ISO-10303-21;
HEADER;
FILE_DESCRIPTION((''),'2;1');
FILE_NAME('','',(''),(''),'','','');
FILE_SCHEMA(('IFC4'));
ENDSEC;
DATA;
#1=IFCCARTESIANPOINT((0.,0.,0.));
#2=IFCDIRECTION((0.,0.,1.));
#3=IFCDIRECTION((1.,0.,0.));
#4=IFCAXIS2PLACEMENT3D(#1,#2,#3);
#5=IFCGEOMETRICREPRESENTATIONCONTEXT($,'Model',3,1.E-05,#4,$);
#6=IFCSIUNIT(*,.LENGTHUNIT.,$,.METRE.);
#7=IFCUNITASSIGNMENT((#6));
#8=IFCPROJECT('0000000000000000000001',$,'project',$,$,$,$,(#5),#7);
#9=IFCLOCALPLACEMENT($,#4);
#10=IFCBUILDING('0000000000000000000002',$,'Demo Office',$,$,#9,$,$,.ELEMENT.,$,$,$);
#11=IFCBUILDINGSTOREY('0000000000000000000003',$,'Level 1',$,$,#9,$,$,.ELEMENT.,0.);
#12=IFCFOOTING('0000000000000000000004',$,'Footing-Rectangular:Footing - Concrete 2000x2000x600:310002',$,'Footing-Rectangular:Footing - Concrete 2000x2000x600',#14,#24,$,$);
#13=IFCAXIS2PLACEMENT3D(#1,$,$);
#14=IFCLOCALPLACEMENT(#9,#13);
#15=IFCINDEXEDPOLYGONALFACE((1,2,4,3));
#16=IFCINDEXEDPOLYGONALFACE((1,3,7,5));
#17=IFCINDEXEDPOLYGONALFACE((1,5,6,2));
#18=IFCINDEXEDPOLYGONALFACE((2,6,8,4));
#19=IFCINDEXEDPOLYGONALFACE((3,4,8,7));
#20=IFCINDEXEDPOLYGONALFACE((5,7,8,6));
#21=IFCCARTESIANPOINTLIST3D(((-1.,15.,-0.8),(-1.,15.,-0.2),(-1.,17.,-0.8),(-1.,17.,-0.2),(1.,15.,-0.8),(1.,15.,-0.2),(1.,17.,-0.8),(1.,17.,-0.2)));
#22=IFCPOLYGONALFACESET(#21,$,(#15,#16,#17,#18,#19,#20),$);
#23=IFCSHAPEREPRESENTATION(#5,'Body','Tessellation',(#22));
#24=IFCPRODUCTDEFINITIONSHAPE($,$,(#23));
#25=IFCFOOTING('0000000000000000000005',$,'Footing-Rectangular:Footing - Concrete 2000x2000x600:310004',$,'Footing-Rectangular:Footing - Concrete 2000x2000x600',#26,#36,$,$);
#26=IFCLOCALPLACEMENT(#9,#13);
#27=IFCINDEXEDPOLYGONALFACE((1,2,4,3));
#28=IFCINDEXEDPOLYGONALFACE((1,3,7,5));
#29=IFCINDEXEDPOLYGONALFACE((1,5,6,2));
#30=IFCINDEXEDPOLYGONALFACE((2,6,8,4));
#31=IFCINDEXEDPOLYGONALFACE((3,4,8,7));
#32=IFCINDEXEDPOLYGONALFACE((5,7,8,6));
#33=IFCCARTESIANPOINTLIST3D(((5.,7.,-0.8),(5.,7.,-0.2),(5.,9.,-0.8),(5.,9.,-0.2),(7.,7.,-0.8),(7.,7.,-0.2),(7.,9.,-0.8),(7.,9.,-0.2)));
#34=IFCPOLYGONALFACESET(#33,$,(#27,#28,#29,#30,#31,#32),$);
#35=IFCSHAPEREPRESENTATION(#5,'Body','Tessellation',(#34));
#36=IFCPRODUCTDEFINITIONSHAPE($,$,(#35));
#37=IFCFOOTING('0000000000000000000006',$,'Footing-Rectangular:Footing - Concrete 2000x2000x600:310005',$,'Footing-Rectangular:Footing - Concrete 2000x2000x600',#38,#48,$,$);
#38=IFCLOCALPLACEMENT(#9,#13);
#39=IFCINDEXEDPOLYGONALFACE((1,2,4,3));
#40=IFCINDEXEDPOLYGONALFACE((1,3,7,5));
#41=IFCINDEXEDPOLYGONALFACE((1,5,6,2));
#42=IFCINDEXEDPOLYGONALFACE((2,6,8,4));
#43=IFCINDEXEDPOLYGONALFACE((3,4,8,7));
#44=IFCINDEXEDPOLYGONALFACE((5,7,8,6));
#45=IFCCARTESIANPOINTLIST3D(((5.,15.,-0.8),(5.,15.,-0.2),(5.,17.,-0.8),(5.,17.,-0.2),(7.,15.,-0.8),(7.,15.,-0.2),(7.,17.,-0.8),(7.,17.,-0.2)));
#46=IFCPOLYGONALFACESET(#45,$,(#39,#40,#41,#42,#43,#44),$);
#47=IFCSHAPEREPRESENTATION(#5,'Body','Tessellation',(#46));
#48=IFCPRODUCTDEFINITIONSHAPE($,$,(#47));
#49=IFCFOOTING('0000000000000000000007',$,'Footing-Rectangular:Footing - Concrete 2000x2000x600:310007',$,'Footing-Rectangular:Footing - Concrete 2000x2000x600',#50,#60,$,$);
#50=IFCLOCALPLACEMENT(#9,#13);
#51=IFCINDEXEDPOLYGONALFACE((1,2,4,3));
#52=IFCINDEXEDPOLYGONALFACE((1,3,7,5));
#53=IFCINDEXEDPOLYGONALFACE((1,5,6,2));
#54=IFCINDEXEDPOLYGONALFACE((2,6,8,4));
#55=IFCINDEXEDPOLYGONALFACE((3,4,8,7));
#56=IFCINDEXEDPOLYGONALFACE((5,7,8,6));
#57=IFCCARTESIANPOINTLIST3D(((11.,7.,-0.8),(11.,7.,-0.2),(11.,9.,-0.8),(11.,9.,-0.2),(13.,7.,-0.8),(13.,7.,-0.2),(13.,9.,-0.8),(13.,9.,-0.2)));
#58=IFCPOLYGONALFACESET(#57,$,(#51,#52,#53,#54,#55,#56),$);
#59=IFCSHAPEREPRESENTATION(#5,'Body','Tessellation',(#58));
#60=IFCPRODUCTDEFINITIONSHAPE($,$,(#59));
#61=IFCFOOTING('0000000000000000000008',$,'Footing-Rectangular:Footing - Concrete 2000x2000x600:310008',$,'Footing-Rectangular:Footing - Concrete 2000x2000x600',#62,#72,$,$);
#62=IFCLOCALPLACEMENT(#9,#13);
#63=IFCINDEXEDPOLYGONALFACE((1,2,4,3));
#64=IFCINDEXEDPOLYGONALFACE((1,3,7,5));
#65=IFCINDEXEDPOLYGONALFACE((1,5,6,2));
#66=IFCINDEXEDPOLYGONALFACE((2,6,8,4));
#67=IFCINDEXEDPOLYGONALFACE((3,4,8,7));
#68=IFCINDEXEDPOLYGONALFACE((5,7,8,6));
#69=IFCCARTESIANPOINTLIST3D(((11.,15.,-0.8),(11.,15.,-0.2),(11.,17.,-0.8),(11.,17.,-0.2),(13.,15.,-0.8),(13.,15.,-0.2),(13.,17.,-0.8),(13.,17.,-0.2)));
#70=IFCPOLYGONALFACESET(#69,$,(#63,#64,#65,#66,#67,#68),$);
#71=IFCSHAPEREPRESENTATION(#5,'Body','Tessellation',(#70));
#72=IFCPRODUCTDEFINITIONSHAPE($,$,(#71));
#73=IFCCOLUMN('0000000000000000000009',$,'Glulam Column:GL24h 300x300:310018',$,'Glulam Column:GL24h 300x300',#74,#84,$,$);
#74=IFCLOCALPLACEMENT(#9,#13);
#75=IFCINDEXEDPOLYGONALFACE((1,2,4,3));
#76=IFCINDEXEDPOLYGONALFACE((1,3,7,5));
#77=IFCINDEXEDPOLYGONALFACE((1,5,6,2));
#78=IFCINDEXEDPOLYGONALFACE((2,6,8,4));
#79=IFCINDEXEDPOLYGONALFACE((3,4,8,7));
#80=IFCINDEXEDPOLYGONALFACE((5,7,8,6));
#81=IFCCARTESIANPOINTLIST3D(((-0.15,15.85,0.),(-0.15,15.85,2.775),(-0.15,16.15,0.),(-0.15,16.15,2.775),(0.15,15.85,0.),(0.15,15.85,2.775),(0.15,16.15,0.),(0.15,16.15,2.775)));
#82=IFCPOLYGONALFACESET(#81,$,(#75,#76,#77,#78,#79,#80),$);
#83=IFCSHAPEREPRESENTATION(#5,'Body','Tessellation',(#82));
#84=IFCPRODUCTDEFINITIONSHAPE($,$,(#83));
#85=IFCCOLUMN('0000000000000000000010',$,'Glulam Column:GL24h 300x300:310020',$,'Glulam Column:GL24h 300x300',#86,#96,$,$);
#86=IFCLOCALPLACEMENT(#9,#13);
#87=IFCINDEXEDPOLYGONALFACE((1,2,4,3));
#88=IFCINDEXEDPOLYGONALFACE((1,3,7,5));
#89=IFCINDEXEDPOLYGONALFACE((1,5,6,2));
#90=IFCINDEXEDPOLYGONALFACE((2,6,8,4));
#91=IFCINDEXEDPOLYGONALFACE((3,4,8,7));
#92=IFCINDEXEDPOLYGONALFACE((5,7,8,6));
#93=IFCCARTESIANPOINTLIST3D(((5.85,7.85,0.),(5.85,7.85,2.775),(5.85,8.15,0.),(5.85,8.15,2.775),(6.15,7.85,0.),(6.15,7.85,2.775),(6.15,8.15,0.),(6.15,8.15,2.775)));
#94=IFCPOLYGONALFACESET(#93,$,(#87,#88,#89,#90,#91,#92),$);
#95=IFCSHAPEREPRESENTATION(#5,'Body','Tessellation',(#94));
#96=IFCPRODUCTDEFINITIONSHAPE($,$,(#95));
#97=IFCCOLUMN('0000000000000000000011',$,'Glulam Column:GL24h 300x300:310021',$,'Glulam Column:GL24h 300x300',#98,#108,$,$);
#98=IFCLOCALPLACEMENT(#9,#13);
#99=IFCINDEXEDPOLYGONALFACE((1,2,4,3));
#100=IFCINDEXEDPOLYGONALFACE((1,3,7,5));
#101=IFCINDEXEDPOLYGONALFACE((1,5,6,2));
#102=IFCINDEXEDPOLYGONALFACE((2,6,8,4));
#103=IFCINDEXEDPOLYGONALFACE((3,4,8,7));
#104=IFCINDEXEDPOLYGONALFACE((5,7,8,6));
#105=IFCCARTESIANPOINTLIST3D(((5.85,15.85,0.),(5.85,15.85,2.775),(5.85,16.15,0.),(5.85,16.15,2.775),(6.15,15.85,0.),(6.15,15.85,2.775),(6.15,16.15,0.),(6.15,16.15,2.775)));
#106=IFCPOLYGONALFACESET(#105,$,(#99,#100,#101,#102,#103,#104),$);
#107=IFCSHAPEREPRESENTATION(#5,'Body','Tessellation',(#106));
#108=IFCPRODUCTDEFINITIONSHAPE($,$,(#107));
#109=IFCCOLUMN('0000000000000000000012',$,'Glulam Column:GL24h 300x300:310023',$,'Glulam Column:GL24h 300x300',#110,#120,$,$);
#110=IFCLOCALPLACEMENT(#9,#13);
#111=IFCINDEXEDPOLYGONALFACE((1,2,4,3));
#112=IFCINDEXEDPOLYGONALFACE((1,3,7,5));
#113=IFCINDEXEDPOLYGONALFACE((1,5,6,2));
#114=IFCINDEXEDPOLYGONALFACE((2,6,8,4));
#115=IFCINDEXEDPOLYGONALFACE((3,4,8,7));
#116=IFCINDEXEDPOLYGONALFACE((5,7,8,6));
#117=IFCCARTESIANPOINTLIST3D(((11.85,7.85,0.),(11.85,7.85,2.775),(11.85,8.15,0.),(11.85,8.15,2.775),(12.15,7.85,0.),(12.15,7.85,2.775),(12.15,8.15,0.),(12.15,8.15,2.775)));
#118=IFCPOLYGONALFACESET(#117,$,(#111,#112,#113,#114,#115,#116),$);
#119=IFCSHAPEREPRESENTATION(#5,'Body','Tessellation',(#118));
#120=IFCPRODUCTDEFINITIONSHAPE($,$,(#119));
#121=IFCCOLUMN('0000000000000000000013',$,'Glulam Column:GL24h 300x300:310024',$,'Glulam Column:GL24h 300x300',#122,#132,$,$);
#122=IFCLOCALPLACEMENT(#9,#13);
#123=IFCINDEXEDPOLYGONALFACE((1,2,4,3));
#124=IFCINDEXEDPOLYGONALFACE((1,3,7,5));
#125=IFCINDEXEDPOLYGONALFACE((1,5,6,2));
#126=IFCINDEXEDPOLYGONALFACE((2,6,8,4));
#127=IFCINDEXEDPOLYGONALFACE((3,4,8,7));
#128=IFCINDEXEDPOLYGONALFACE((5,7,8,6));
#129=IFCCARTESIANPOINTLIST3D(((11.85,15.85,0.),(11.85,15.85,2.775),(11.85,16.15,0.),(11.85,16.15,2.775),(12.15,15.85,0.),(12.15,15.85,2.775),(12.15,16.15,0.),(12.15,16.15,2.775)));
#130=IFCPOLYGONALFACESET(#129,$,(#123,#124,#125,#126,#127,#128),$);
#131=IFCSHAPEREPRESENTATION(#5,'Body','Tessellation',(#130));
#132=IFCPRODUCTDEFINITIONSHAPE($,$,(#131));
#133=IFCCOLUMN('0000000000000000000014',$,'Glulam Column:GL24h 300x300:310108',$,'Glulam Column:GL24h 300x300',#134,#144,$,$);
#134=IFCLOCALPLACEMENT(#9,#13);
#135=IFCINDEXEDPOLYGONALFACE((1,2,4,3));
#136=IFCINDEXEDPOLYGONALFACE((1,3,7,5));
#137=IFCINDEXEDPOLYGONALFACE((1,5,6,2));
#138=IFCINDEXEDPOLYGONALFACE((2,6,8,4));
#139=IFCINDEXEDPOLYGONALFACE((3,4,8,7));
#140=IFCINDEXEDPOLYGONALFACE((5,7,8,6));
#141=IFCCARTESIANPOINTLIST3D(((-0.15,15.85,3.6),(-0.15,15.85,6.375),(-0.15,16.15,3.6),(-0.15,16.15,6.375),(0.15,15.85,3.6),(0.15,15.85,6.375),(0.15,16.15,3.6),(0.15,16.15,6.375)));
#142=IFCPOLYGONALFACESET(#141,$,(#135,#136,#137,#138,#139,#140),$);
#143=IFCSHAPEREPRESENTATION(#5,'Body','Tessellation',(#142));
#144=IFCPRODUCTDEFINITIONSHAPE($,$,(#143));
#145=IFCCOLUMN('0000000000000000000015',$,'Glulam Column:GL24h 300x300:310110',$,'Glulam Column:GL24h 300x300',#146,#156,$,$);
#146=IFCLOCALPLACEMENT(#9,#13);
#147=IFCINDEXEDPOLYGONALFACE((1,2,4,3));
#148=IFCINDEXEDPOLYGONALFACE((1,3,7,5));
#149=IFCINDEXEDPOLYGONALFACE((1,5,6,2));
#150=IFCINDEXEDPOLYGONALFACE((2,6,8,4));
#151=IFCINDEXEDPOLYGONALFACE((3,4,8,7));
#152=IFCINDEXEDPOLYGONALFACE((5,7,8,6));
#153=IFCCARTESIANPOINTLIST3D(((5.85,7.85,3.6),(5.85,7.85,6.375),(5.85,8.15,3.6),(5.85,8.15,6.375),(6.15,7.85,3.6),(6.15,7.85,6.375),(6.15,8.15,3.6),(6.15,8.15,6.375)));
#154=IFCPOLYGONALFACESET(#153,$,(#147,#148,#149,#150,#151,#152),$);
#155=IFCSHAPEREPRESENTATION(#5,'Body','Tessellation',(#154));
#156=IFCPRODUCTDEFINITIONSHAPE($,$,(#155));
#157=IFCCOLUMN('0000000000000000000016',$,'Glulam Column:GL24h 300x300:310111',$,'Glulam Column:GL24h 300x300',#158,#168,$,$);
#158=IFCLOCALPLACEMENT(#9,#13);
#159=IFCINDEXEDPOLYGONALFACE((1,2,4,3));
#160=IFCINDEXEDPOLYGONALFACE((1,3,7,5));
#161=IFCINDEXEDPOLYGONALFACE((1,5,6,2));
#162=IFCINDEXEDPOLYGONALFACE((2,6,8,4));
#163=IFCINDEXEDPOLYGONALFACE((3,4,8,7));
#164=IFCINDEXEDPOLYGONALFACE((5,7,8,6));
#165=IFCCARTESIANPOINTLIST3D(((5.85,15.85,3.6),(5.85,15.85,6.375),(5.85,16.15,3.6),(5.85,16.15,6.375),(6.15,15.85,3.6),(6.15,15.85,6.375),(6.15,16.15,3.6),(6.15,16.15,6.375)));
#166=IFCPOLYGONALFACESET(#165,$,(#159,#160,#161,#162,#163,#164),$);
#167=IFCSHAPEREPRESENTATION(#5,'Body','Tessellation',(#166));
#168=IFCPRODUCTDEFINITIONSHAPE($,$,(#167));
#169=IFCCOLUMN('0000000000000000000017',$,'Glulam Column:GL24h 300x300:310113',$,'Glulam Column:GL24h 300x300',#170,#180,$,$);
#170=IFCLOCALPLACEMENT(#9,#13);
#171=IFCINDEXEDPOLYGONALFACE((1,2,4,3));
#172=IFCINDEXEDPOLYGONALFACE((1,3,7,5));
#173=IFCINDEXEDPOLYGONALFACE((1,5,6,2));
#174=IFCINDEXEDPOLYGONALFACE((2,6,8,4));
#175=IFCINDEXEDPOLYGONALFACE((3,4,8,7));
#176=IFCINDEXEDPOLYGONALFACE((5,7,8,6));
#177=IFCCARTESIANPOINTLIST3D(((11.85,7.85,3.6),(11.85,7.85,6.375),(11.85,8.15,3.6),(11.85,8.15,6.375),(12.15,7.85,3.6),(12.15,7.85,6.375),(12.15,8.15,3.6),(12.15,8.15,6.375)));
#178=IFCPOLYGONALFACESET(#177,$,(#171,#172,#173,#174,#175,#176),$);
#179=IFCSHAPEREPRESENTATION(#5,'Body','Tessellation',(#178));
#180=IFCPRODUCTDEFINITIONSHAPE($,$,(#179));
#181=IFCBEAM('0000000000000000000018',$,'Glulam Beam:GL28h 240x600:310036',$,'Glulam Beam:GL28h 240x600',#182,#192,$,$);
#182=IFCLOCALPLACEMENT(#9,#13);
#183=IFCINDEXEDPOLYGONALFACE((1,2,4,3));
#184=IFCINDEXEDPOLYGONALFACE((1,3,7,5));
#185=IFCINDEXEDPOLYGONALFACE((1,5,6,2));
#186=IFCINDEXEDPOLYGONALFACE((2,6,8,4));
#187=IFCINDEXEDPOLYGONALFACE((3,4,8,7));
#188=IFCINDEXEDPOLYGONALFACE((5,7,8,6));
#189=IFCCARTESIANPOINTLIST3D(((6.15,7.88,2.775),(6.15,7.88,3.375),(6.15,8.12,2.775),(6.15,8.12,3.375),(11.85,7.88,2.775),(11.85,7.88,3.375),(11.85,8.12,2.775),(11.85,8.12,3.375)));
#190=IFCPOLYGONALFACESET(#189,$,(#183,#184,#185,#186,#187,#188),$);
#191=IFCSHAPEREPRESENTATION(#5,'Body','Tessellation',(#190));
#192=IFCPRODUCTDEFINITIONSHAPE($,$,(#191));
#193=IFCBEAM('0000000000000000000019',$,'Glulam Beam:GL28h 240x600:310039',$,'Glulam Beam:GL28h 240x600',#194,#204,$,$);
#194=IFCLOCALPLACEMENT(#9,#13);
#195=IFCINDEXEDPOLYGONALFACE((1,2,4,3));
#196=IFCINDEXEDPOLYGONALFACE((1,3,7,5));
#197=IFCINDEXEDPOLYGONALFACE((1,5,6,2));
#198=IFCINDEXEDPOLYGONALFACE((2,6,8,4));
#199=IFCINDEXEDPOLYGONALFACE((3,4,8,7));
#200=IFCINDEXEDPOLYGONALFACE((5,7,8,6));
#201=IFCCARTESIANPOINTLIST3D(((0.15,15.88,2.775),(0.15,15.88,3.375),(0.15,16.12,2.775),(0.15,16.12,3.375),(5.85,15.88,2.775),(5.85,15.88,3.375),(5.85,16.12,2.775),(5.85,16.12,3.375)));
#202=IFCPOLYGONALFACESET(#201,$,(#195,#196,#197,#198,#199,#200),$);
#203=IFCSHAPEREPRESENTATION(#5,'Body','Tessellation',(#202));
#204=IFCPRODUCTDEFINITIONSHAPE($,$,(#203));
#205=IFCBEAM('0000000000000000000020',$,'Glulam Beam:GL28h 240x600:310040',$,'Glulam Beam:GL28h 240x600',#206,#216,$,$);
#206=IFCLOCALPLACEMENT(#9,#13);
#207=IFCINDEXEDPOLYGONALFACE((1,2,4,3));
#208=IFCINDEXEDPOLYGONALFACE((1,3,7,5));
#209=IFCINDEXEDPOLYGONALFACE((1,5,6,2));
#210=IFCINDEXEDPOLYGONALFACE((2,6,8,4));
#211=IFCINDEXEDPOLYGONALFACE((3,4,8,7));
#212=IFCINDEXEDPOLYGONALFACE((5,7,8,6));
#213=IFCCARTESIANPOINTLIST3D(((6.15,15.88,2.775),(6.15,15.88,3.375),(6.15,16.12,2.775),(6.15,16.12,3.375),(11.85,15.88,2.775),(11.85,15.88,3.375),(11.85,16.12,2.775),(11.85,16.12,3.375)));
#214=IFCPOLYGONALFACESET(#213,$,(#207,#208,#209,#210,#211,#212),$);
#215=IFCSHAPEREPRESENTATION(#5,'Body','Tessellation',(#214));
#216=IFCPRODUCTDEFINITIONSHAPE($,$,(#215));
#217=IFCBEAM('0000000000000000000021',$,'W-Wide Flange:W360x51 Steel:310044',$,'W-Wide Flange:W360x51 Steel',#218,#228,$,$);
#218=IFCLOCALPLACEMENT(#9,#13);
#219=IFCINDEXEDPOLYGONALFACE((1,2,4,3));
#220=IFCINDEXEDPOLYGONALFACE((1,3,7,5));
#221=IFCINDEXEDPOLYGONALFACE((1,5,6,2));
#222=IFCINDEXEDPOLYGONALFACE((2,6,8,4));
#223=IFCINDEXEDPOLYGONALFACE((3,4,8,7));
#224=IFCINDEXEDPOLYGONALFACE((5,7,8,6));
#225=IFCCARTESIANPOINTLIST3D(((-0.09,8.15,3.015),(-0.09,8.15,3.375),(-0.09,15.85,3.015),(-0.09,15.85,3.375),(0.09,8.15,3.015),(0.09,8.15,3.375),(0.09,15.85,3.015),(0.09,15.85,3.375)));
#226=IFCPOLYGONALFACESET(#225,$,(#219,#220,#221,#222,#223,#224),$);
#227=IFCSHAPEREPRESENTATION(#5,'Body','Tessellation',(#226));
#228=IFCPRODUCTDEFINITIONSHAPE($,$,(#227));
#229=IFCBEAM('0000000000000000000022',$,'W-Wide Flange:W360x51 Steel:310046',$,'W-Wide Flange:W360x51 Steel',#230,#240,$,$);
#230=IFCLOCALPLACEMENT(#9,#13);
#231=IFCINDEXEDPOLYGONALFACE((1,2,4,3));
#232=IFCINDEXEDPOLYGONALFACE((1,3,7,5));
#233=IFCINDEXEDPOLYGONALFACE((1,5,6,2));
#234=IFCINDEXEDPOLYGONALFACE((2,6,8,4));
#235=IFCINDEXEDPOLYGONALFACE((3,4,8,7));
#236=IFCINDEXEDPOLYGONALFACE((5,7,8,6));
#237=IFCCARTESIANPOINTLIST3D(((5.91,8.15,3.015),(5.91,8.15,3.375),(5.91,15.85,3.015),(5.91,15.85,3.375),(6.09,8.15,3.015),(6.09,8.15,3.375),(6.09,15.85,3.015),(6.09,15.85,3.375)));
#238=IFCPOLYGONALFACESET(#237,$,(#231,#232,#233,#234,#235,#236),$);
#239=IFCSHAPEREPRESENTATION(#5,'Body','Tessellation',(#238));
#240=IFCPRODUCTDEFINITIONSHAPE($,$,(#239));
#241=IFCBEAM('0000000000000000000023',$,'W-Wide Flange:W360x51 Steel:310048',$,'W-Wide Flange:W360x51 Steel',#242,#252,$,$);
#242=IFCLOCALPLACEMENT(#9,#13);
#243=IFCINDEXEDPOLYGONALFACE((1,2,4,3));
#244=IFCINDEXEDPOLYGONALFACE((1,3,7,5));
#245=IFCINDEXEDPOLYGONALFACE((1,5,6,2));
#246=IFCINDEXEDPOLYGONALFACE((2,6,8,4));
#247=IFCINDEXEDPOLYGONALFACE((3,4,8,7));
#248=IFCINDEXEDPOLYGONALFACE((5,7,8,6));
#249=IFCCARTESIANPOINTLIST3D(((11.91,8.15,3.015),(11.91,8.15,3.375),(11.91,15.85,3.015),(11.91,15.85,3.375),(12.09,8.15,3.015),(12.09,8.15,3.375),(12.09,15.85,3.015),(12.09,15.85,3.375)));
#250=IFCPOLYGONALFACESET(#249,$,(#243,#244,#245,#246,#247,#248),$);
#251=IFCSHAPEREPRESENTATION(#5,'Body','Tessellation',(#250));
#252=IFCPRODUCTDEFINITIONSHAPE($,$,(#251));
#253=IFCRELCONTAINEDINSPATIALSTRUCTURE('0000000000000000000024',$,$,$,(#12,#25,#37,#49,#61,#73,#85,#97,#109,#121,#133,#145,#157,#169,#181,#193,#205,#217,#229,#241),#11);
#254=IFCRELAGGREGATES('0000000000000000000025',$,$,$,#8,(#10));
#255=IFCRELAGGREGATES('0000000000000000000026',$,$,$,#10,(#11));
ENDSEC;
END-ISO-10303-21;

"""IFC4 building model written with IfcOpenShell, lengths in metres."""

from ifc_helpers import new_model, si_unit, frame, origin_with_axes, origin_2d, place, context, project, spatial, rectangle, extrude, element, save


model = new_model("IFC4")

# Units and contexts
model_context = context("Model", 3, precision=1e-05, world=origin_with_axes())
ifc_project = project(units=[si_unit("LENGTHUNIT", "METRE")], contexts=[model_context])

# Building, storey
placement = place(None, origin_with_axes())
building = spatial("IfcBuilding", under=ifc_project, at=placement, Name="Demo Office", CompositionType="ELEMENT")
storey = spatial("IfcBuildingStorey", under=building, at=placement, Name="Level 1", CompositionType="ELEMENT", Elevation=0.0)

# Footings
for number, where, name in (
    (1, (0.0, 16.0, -0.8), "Footing-Rectangular:Footing - Concrete 2000x2000x600:310002"),
    (2, (6.0, 8.0, -0.8), "Footing-Rectangular:Footing - Concrete 2000x2000x600:310004"),
    (3, (6.0, 16.0, -0.8), "Footing-Rectangular:Footing - Concrete 2000x2000x600:310005"),
    (4, (12.0, 8.0, -0.8), "Footing-Rectangular:Footing - Concrete 2000x2000x600:310007"),
    (5, (12.0, 16.0, -0.8), "Footing-Rectangular:Footing - Concrete 2000x2000x600:310008"),
):
    element("IfcFooting", number, at=place(placement, frame(where)), inside=storey, Name=name, ObjectType="Footing-Rectangular:Footing - Concrete 2000x2000x600", context=model_context, shape_type="SweptSolid", body=[
        extrude(rectangle(XDim=2.0, YDim=2.0, at=origin_2d()), origin_with_axes(), (0.0, 0.0, 1.0), 0.6),
    ])

# Columns
for number, where, name in (
    (6, (0.0, 16.0, 0.0), "Glulam Column:GL24h 300x300:310018"),
    (7, (6.0, 8.0, 0.0), "Glulam Column:GL24h 300x300:310020"),
    (8, (6.0, 16.0, 0.0), "Glulam Column:GL24h 300x300:310021"),
    (9, (12.0, 8.0, 0.0), "Glulam Column:GL24h 300x300:310023"),
    (10, (12.0, 16.0, 0.0), "Glulam Column:GL24h 300x300:310024"),
    (11, (0.0, 16.0, 3.6), "Glulam Column:GL24h 300x300:310108"),
    (12, (6.0, 8.0, 3.6), "Glulam Column:GL24h 300x300:310110"),
    (13, (6.0, 16.0, 3.6), "Glulam Column:GL24h 300x300:310111"),
    (14, (12.0, 8.0, 3.6), "Glulam Column:GL24h 300x300:310113"),
):
    element("IfcColumn", number, at=place(placement, frame(where)), inside=storey, Name=name, ObjectType="Glulam Column:GL24h 300x300", context=model_context, shape_type="SweptSolid", body=[
        extrude(rectangle(XDim=0.3, YDim=0.3, at=origin_2d()), origin_with_axes(), (0.0, 0.0, 1.0), 2.775),
    ])

# Beams
for number, where, name in (
    (15, (9.0, 8.0, 2.775), "Glulam Beam:GL28h 240x600:310036"),
    (16, (3.0, 16.0, 2.775), "Glulam Beam:GL28h 240x600:310039"),
    (17, (9.0, 16.0, 2.775), "Glulam Beam:GL28h 240x600:310040"),
):
    element("IfcBeam", number, at=place(placement, frame(where)), inside=storey, Name=name, ObjectType="Glulam Beam:GL28h 240x600", context=model_context, shape_type="SweptSolid", body=[
        extrude(rectangle(XDim=5.7, YDim=0.24, at=origin_2d()), origin_with_axes(), (0.0, 0.0, 1.0), 0.6),
    ])
for number, where, name in (
    (18, (0.0, 12.0, 3.015), "W-Wide Flange:W360x51 Steel:310044"),
    (19, (6.0, 12.0, 3.015), "W-Wide Flange:W360x51 Steel:310046"),
    (20, (12.0, 12.0, 3.015), "W-Wide Flange:W360x51 Steel:310048"),
):
    element("IfcBeam", number, at=place(placement, frame(where)), inside=storey, Name=name, ObjectType="W-Wide Flange:W360x51 Steel", context=model_context, shape_type="SweptSolid", body=[
        extrude(rectangle(XDim=0.18, YDim=7.7, at=origin_2d()), origin_with_axes(), (0.0, 0.0, 1.0), 0.36),
    ])

save(model, "model.ifc")
